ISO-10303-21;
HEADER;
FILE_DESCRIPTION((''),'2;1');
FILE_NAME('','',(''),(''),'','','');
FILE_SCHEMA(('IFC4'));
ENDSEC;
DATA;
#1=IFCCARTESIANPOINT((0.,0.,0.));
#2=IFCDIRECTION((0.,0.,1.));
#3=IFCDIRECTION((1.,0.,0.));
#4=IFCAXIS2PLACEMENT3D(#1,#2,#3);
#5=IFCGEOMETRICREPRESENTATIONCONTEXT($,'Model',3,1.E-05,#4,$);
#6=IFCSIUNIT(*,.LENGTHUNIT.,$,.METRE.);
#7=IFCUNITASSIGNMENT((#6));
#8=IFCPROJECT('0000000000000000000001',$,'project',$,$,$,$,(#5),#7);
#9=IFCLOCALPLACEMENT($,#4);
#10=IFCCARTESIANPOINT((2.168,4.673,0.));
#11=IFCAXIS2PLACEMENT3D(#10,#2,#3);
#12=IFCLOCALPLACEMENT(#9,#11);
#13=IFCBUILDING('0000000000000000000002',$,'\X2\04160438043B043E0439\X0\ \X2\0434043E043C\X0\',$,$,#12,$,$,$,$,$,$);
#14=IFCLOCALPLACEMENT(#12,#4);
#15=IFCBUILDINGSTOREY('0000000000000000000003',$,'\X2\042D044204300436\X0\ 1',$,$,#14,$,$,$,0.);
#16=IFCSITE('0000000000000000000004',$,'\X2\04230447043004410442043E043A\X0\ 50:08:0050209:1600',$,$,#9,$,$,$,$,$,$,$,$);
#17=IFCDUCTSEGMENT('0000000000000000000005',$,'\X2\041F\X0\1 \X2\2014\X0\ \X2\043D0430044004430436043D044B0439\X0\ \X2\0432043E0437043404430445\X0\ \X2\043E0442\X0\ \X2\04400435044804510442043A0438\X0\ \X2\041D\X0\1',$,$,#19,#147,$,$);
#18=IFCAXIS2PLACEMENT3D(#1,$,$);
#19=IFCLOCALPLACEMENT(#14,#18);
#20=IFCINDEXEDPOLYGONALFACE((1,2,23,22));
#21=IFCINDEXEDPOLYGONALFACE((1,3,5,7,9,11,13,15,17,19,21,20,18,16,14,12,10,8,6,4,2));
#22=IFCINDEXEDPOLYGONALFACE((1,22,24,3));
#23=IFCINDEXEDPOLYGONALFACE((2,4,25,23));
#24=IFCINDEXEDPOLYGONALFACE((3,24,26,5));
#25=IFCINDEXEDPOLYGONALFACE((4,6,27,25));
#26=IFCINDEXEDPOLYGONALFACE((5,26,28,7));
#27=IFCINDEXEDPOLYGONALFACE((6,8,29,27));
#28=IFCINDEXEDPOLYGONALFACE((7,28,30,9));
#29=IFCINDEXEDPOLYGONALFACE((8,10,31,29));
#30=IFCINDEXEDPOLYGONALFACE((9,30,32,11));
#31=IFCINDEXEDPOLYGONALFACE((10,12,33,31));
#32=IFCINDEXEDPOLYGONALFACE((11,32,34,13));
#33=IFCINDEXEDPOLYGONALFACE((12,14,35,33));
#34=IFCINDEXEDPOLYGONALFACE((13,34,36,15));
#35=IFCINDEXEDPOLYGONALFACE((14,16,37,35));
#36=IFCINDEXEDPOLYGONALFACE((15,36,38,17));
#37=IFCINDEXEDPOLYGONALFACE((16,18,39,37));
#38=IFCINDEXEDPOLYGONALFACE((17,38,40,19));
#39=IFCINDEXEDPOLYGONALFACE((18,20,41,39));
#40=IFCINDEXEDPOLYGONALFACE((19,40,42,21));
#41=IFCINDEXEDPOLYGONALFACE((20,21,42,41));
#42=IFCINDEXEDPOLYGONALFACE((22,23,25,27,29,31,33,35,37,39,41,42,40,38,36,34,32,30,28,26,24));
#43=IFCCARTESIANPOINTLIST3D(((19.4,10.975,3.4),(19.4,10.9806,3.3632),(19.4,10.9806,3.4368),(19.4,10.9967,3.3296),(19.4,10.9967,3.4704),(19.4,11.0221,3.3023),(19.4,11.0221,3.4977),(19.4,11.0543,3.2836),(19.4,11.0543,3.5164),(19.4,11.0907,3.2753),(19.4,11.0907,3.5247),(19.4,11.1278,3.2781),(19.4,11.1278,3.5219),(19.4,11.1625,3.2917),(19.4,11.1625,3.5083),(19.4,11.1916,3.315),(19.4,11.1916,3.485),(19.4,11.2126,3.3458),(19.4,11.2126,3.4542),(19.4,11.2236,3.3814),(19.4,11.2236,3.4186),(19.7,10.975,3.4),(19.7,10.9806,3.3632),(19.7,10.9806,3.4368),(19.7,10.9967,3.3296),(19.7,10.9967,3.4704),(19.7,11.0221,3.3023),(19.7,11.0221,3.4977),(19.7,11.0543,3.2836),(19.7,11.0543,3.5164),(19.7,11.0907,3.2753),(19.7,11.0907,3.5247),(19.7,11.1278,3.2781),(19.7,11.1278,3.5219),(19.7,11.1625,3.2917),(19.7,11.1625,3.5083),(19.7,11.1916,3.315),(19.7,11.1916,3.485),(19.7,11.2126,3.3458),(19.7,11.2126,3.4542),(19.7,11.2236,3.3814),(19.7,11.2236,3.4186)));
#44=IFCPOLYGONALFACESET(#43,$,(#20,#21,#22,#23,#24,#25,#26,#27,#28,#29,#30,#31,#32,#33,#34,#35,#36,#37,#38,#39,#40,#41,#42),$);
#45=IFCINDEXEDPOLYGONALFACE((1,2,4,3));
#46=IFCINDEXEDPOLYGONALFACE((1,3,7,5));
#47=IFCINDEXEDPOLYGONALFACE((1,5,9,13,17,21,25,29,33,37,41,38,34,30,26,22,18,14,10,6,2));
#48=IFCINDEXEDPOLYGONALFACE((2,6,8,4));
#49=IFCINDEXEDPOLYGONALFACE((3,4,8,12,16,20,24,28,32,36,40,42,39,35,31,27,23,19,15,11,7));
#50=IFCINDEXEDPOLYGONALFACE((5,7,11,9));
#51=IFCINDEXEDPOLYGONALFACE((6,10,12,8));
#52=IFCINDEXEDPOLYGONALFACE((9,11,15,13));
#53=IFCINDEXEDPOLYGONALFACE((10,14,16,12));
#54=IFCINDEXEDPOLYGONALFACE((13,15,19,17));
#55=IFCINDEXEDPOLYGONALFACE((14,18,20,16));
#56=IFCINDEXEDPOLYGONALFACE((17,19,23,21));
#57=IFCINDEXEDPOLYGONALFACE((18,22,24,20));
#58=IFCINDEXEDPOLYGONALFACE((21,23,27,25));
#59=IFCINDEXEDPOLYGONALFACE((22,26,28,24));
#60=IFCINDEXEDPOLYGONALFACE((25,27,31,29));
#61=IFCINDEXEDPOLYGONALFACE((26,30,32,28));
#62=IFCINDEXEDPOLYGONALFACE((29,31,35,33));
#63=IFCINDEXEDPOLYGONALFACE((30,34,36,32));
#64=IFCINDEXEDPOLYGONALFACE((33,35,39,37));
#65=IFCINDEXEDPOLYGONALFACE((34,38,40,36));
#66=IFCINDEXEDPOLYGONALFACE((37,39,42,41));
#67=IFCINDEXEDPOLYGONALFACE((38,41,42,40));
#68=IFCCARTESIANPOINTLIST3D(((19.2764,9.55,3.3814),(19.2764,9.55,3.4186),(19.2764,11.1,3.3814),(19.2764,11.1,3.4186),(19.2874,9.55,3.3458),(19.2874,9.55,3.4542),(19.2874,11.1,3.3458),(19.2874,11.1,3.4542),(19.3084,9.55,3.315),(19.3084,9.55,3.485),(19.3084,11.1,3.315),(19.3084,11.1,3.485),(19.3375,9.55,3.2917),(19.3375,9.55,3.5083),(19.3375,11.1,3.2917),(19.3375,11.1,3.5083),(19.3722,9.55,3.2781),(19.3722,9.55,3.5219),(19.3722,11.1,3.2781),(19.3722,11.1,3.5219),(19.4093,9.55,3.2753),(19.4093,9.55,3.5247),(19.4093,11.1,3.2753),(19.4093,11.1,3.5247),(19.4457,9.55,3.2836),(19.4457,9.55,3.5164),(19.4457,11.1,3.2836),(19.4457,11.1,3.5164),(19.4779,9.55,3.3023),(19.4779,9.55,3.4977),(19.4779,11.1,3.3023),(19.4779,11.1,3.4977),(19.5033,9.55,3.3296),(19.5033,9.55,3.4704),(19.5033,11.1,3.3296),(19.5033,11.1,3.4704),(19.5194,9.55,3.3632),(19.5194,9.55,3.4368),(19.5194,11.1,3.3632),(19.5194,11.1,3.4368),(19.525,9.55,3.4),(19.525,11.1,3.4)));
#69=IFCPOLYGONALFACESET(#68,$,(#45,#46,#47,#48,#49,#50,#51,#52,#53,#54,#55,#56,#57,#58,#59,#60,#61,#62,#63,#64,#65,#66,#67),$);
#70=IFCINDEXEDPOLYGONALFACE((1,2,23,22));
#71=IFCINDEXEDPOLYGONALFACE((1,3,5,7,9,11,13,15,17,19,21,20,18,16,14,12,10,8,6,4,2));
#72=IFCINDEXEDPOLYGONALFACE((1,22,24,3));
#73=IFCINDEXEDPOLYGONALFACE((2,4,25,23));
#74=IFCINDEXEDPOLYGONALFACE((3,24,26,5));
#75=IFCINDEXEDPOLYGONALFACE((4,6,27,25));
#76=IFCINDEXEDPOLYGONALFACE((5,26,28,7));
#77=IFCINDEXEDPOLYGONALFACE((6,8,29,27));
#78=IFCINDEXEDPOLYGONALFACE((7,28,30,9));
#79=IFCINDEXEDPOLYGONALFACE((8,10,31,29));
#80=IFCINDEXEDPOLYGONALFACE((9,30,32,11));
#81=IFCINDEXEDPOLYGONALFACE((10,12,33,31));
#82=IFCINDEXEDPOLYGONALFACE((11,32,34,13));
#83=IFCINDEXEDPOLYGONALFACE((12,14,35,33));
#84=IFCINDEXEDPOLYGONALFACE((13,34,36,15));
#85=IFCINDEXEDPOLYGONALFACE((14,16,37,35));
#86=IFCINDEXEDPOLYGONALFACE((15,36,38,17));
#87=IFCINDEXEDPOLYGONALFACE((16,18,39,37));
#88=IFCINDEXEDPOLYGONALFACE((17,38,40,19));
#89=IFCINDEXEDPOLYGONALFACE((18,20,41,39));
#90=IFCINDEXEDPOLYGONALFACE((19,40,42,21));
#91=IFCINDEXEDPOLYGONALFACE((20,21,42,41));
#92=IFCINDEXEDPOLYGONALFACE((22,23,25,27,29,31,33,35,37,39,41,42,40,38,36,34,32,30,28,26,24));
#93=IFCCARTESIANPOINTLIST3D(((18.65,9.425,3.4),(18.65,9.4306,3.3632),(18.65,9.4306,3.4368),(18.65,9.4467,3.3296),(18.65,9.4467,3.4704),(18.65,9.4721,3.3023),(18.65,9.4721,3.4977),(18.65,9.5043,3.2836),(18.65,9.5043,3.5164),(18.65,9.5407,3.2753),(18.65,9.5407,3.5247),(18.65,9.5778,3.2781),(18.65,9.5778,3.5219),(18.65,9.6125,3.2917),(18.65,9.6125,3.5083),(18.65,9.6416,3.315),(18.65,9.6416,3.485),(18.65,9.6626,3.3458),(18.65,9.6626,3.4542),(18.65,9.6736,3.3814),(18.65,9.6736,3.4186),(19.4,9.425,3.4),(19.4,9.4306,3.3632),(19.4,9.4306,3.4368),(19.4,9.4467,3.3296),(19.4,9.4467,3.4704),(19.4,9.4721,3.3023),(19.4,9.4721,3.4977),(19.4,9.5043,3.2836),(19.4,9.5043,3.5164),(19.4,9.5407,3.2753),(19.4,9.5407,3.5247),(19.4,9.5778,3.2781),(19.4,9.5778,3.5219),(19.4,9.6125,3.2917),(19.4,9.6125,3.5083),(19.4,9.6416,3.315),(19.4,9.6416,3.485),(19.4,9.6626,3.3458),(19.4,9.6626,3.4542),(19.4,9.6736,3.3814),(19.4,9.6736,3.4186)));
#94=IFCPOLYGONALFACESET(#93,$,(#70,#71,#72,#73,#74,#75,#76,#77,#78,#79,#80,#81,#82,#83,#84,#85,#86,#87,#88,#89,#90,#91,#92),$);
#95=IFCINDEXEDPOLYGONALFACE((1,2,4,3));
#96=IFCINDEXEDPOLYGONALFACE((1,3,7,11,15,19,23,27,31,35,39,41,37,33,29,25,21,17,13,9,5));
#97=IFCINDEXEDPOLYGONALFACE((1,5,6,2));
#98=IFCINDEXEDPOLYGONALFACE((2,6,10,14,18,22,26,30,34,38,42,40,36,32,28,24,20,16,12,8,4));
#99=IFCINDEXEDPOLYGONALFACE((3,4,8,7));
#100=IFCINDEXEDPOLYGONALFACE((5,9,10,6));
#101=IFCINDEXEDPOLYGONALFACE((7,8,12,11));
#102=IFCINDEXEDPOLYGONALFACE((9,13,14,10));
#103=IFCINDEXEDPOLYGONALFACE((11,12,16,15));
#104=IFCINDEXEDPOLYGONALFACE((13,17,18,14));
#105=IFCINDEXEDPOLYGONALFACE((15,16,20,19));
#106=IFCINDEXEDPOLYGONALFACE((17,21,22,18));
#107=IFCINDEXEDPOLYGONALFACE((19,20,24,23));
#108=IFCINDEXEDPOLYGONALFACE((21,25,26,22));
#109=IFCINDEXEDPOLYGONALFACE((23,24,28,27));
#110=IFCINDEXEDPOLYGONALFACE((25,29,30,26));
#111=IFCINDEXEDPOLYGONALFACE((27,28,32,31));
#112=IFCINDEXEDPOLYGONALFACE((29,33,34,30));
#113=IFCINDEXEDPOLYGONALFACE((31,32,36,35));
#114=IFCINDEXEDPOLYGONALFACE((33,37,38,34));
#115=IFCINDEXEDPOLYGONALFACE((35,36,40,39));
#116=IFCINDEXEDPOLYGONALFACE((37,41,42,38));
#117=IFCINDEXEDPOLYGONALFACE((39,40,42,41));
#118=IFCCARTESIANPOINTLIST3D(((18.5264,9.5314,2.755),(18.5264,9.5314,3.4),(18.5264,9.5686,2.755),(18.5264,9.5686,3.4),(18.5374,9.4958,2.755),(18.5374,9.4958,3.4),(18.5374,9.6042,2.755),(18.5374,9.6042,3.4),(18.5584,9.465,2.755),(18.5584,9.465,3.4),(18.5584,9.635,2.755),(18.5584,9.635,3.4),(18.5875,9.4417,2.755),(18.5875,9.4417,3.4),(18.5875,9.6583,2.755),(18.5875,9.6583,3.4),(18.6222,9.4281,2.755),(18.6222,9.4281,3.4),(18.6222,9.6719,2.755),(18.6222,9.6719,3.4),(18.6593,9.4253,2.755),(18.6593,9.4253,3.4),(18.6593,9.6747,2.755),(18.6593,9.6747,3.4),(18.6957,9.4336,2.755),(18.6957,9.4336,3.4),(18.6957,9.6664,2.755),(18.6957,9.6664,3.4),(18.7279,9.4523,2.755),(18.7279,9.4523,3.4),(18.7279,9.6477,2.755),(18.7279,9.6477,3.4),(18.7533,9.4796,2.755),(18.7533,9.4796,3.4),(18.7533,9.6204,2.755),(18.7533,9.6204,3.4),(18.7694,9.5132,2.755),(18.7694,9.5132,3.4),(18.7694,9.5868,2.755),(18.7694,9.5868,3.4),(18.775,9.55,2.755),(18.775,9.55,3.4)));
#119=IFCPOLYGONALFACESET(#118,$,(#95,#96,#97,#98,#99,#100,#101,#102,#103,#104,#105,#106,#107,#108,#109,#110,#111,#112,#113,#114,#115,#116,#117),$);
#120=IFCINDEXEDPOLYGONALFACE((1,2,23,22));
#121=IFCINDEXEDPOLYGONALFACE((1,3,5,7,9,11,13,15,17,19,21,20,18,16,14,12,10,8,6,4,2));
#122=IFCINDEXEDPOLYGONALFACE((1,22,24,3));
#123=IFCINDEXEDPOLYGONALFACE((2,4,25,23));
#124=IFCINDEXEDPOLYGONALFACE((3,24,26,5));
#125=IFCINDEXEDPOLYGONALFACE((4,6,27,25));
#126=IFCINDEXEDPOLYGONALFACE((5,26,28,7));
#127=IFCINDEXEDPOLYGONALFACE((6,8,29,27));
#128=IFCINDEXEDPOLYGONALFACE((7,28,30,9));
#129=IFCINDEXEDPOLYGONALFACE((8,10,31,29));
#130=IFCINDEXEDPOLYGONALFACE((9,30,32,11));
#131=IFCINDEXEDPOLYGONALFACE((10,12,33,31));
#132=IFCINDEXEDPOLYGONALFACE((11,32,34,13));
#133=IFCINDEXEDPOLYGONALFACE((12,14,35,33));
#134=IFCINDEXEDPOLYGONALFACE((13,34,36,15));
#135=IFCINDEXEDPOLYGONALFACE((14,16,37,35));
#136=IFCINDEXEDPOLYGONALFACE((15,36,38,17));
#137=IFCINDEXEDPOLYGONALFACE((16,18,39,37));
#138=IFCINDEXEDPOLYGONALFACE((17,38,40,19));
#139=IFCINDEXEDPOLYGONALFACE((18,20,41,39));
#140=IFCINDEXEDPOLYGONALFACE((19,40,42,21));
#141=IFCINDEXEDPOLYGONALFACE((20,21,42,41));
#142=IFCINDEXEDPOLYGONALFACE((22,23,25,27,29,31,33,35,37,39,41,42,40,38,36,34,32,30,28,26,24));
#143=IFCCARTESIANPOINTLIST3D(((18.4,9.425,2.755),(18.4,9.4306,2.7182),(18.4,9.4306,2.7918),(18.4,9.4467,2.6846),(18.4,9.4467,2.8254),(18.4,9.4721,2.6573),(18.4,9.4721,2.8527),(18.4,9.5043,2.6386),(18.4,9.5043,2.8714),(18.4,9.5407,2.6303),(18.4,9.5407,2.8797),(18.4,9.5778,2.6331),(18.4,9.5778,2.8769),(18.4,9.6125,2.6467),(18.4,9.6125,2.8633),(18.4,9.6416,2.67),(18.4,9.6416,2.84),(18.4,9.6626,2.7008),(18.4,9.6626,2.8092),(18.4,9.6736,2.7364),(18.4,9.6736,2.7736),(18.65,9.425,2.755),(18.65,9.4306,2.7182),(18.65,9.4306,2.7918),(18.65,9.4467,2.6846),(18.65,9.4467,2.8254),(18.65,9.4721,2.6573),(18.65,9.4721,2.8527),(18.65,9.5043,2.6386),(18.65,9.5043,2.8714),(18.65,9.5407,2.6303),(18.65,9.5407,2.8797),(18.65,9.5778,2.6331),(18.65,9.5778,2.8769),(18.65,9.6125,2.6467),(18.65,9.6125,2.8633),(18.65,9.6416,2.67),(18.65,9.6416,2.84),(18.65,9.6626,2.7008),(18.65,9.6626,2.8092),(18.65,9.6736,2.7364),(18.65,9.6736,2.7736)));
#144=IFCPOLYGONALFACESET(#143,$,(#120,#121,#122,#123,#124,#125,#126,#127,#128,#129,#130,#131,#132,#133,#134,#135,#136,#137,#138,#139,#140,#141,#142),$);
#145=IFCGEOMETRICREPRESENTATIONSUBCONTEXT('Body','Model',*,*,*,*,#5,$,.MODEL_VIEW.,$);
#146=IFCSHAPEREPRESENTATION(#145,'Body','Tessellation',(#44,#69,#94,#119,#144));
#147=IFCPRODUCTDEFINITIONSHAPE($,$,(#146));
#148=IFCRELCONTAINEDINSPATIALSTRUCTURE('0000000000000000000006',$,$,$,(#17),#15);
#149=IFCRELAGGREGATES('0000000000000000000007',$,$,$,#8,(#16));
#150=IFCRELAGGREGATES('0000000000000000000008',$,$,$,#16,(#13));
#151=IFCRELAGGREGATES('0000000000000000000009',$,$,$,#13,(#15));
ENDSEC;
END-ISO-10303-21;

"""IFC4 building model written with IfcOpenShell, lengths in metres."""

from ifc_helpers import new_model, si_unit, frame, origin_with_axes, origin_2d, place, context, subcontext, project, spatial, circle, extrude, element, save


model = new_model("IFC4")

# Units and contexts
model_context = context("Model", 3, precision=1e-05, world=origin_with_axes())
body_context = subcontext(model_context, "Body", "Model", "MODEL_VIEW")
ifc_project = project(units=[si_unit("LENGTHUNIT", "METRE")], contexts=[model_context])

# Site, building, storey
site_placement = place(None, origin_with_axes())
site = spatial("IfcSite", under=ifc_project, at=site_placement, Name="Участок 50:08:0050209:1600")
building_placement = place(site_placement, frame((2.168, 4.673, 0.0), z_axis=(0.0, 0.0, 1.0), x_axis=(1.0, 0.0, 0.0)))
building = spatial("IfcBuilding", under=site, at=building_placement, Name="Жилой дом")
storey_placement = place(building_placement, origin_with_axes())
storey = spatial("IfcBuildingStorey", under=building, at=storey_placement, Name="Этаж 1", Elevation=0.0)

# Duct segment
duct_segment_1_placement = place(storey_placement, origin_with_axes())
element("IfcDuctSegment", 1, at=duct_segment_1_placement, inside=storey, Name="П1 — наружный воздух от решётки Н1", context=body_context, shape_type="SweptSolid", body=[
    extrude(circle(Radius=0.125, at=origin_2d()), frame((19.7, 11.1, 3.4), z_axis=(-1.0, 0.0, 0.0), x_axis=(0.0, -1.0, 0.0)), (0.0, 0.0, 1.0), 0.3),
    extrude(circle(Radius=0.125, at=origin_2d()), frame((19.4, 11.1, 3.4), z_axis=(0.0, -1.0, 0.0), x_axis=(1.0, 0.0, 0.0)), (0.0, 0.0, 1.0), 1.55),
    extrude(circle(Radius=0.125, at=origin_2d()), frame((19.4, 9.55, 3.4), z_axis=(-1.0, 0.0, 0.0), x_axis=(0.0, -1.0, 0.0)), (0.0, 0.0, 1.0), 0.75),
    extrude(circle(Radius=0.125, at=origin_2d()), frame((18.65, 9.55, 3.4), z_axis=(0.0, 0.0, -1.0), x_axis=(1.0, 0.0, 0.0)), (0.0, 0.0, 1.0), 0.645),
    extrude(circle(Radius=0.125, at=origin_2d()), frame((18.65, 9.55, 2.755), z_axis=(-1.0, 0.0, 0.0), x_axis=(0.0, -1.0, 0.0)), (0.0, 0.0, 1.0), 0.25),
])

save(model, "model.ifc")
